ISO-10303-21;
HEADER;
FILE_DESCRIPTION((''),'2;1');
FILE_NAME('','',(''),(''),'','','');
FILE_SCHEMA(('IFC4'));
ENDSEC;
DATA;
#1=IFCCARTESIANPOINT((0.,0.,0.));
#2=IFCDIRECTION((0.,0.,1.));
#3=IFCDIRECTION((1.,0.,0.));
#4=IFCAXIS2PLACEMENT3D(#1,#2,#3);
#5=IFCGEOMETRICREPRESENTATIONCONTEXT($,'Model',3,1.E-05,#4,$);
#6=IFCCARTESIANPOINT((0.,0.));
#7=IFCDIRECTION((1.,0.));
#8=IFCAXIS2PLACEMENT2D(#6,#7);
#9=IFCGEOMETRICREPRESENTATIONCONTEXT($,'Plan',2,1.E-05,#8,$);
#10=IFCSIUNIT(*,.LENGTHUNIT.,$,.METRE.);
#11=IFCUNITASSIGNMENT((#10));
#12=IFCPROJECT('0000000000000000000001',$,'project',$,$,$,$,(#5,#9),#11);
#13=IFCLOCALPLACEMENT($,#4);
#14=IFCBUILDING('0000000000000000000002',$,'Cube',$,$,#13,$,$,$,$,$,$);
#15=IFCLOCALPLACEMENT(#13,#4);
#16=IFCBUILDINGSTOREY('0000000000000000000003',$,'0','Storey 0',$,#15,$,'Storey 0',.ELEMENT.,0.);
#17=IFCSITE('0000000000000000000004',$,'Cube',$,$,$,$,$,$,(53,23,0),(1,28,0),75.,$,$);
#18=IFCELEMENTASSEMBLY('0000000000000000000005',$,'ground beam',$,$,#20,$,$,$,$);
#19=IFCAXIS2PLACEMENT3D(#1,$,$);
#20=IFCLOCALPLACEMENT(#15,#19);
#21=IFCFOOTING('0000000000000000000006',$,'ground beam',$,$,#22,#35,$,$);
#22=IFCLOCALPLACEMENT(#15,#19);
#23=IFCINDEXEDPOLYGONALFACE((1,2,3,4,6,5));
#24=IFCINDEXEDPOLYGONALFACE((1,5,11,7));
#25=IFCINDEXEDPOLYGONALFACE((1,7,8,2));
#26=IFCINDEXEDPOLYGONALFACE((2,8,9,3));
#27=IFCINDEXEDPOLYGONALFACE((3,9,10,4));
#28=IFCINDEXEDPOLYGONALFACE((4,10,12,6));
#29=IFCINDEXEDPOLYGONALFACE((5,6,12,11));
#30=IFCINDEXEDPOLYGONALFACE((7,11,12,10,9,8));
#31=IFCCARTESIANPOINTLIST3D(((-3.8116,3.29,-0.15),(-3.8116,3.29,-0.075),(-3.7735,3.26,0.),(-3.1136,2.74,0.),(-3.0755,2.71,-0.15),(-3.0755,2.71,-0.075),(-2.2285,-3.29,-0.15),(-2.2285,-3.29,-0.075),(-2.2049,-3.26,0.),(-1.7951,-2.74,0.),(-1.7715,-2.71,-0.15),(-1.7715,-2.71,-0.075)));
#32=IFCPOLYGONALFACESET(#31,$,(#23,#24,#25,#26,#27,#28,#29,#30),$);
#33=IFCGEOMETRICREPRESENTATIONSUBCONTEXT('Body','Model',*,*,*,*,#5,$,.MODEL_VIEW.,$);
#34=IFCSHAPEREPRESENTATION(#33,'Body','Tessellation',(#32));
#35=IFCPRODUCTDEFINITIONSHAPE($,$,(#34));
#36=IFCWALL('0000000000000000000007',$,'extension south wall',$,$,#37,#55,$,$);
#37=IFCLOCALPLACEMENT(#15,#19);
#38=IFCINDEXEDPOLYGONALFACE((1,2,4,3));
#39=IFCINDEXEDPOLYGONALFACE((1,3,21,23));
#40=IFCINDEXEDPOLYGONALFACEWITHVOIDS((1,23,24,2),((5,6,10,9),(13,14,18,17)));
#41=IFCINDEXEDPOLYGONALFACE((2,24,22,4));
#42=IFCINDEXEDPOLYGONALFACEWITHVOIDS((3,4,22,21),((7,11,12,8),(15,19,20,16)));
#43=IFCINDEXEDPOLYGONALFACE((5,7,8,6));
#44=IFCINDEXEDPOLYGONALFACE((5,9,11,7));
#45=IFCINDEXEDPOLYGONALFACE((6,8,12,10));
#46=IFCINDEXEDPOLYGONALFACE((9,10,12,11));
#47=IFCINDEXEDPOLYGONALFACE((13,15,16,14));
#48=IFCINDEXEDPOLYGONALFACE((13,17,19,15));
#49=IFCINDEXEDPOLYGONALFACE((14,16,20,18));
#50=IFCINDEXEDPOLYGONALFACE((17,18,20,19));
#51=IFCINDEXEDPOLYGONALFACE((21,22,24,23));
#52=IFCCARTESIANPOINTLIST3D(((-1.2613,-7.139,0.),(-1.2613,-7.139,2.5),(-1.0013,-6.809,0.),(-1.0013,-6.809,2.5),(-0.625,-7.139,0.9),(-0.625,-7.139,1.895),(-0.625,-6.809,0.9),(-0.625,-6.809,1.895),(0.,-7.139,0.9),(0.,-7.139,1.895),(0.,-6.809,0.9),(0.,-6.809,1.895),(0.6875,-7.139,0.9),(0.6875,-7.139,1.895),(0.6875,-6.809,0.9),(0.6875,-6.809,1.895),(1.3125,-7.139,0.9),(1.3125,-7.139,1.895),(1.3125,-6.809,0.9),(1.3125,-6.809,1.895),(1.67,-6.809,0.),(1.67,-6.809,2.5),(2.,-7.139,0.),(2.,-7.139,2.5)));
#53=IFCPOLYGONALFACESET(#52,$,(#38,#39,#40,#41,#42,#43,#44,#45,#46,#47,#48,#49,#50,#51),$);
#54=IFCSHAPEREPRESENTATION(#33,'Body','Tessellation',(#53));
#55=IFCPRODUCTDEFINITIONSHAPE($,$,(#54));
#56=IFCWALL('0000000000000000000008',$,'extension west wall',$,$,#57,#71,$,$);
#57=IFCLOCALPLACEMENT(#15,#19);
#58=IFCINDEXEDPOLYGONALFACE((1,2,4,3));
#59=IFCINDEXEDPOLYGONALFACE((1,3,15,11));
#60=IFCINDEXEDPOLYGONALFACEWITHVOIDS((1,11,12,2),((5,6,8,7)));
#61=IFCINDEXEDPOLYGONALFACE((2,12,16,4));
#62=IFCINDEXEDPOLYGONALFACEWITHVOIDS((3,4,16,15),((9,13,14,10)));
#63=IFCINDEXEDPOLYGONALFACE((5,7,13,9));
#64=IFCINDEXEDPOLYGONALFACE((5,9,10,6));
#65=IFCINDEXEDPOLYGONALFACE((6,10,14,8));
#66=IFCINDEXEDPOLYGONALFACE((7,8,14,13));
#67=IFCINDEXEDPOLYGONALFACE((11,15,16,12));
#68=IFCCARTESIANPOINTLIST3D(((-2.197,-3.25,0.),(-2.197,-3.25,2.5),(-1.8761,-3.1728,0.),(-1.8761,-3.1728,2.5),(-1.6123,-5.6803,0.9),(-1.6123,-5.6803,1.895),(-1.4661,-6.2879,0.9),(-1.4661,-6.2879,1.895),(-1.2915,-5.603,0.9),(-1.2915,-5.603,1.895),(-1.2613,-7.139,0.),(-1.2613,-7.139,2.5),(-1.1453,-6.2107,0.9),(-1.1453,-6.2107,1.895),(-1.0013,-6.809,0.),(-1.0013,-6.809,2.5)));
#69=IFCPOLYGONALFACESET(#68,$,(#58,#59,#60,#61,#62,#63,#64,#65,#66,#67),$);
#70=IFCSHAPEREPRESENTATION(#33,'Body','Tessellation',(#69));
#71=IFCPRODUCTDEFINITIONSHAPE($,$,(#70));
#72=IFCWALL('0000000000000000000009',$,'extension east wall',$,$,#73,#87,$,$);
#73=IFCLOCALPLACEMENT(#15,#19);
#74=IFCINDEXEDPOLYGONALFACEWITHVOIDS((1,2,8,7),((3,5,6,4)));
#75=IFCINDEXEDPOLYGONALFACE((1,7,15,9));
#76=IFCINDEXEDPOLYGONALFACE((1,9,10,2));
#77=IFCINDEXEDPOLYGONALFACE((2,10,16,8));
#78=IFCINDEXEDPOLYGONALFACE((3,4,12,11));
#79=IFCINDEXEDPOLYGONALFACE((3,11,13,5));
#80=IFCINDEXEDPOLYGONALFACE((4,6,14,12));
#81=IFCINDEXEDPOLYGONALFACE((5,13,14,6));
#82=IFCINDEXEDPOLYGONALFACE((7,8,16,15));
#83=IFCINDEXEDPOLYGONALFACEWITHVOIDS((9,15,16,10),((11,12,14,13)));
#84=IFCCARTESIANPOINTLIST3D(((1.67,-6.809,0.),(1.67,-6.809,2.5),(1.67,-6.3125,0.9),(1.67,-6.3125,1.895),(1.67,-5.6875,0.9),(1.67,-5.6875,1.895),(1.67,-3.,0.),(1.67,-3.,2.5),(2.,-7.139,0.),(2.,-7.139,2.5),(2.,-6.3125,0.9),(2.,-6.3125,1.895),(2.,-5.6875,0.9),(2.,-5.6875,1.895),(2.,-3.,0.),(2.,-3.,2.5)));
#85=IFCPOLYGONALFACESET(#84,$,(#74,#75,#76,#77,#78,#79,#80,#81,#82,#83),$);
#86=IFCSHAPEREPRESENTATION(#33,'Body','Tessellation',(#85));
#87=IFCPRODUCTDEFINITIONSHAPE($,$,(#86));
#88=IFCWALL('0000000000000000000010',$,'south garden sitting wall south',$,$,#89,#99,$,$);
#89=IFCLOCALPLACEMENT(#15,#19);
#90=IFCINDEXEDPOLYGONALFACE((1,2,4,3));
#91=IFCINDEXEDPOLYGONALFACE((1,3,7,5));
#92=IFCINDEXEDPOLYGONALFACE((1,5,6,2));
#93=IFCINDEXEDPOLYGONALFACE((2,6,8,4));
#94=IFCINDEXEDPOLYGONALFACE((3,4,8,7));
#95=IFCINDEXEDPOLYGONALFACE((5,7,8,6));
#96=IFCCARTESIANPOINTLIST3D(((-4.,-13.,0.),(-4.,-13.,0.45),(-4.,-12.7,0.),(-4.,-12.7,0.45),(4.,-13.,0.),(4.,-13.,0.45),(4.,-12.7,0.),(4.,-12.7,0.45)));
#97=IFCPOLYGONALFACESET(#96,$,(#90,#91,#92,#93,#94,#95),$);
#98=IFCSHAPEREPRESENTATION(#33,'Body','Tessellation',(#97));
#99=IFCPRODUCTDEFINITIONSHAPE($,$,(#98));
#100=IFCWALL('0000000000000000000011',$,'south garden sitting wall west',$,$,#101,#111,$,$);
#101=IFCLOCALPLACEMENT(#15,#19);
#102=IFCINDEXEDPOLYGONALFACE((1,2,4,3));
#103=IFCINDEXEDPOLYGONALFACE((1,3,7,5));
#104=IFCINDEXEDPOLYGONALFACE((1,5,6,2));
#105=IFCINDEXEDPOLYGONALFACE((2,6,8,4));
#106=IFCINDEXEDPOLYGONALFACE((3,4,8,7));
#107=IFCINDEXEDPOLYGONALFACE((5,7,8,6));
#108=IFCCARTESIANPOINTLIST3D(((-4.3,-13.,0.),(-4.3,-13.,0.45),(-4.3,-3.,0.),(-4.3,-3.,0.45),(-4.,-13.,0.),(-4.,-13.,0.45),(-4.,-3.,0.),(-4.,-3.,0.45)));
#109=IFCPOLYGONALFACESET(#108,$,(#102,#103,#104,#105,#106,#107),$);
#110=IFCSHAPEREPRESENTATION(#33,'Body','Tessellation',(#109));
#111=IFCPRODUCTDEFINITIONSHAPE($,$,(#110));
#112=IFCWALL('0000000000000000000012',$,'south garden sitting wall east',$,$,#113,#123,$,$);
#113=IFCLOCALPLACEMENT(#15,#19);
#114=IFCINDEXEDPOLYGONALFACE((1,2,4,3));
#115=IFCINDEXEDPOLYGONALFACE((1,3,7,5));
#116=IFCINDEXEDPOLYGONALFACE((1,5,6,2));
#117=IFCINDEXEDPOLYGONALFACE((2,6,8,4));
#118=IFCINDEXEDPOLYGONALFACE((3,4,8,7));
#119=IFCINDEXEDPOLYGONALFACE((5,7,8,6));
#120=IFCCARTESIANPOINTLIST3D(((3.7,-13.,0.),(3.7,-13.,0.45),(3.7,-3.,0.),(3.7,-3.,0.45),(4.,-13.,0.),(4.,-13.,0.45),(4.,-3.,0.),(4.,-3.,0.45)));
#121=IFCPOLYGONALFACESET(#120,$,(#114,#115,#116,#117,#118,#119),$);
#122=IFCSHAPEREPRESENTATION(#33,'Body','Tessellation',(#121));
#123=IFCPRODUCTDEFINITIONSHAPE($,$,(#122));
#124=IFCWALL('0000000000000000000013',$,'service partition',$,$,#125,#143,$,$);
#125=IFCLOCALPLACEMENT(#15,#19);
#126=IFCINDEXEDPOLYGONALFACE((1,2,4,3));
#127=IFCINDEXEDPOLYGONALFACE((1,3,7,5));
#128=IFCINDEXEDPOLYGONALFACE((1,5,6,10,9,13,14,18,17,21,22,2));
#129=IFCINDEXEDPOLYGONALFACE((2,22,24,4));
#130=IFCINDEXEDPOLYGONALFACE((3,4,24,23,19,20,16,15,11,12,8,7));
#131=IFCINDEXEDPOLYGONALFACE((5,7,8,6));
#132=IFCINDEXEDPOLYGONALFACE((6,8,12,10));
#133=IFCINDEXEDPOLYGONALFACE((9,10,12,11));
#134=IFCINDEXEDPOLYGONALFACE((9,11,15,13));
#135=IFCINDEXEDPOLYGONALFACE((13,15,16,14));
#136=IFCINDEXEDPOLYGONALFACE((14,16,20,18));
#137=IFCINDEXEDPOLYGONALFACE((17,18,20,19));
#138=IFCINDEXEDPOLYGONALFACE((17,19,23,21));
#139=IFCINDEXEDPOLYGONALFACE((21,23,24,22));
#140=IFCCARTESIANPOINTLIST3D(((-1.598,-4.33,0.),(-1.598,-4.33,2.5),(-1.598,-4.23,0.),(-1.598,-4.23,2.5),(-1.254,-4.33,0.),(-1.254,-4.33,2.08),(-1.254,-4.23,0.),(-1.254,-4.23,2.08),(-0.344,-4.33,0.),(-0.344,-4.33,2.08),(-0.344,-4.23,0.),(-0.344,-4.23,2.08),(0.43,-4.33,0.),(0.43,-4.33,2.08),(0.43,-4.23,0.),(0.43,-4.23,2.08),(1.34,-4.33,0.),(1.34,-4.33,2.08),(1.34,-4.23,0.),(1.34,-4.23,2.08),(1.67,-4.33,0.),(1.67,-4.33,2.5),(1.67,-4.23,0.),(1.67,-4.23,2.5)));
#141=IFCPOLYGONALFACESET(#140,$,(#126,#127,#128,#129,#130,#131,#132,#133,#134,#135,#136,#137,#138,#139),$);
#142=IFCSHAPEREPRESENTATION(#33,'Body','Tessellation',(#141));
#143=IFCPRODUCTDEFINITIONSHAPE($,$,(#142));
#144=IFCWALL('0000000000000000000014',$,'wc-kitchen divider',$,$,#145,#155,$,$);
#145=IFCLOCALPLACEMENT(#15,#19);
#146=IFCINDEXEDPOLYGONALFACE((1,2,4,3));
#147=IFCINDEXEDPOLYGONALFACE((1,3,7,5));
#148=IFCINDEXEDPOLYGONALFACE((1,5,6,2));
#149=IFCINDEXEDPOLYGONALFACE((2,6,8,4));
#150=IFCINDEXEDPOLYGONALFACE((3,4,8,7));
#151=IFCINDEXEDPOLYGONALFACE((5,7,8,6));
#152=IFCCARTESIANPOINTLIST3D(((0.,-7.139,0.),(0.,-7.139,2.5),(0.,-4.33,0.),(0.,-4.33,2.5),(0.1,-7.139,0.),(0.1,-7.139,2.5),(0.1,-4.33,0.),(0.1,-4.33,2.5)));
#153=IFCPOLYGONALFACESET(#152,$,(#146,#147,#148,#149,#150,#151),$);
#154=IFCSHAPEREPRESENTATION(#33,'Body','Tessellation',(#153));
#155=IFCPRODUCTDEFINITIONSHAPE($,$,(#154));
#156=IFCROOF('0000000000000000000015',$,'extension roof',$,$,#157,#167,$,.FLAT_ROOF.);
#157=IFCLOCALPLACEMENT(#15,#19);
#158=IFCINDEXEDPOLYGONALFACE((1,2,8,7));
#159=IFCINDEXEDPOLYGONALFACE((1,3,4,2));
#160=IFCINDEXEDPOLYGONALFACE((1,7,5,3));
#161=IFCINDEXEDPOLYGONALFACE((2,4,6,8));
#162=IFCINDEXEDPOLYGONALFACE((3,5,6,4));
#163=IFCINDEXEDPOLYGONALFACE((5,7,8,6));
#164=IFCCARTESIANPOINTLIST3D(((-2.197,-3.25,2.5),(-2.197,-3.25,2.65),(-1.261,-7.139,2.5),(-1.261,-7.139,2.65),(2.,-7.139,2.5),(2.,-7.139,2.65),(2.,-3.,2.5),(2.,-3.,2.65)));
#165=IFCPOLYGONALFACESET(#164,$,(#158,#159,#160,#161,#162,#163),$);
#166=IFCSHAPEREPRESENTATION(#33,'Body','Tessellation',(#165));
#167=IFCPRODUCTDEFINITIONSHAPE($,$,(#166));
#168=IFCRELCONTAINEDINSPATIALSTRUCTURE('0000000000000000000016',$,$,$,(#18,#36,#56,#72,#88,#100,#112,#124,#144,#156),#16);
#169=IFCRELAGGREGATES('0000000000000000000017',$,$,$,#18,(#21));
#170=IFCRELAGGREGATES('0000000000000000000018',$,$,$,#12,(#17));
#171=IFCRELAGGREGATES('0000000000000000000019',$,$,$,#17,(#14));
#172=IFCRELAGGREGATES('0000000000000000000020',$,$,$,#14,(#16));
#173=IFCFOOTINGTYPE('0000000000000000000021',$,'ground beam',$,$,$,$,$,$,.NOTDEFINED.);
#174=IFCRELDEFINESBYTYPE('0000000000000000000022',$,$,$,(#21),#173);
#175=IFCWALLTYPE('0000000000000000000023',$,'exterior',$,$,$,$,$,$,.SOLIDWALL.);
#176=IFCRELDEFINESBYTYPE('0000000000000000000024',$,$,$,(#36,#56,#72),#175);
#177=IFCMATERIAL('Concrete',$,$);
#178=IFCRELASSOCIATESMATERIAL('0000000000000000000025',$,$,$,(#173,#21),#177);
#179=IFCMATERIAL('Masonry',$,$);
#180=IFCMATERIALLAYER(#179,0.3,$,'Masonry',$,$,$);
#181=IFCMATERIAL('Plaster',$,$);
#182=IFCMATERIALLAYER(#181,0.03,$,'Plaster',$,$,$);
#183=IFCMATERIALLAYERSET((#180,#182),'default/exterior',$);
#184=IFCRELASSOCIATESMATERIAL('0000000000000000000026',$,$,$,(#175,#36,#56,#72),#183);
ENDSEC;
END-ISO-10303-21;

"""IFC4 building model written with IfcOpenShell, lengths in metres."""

from ifc_helpers import new_model, si_unit, frame, origin_with_axes, origin_2d_with_axis, place, context, subcontext, project, spatial, polyline, line, indexed_curve, outline, extrude, clip, halfspace, material, layer, layer_set, layer_usage, material_profile, profile_set, profile_usage, type_object, element, aggregate, save


model = new_model("IFC4")

# Units and contexts
model_context = context("Model", 3, precision=1e-05, world=origin_with_axes())
plan_context = context("Plan", 2, precision=1e-05, world=origin_2d_with_axis())
body_context_1 = subcontext(model_context, "Body", "Model", "MODEL_VIEW")
ifc_project = project(units=[si_unit("LENGTHUNIT", "METRE")], contexts=[model_context, plan_context])

# Site, building, storey
site = spatial("IfcSite", under=ifc_project, Name="Cube", RefLatitude=(53, 23, 0), RefLongitude=(1, 28, 0), RefElevation=75.0)
building_placement = place(None, origin_with_axes())
building = spatial("IfcBuilding", under=site, at=building_placement, Name="Cube")
storey_placement = place(building_placement, origin_with_axes())
storey = spatial("IfcBuildingStorey", under=building, at=storey_placement, Name="0", Description="Storey 0", LongName="Storey 0", CompositionType="ELEMENT", Elevation=0.0)

# Element assembly, footing
assembly_placement = place(storey_placement, origin_with_axes())
assembly = element("IfcElementAssembly", 1, at=assembly_placement, inside=storey, Name="ground beam")
ifc_material_1 = material(Name="Concrete")
ifc_material_profile = material_profile(ifc_material_1, outline(polyline([(-0.26, 0.0), (-0.29, -0.075), (-0.29, -0.15), (0.29, -0.15), (0.29, -0.075), (0.26, 0.0), (-0.26, 0.0)])))
ifc_profile_set = profile_set([ifc_material_profile])
ifc_profile_usage = profile_usage(ifc_profile_set)
footing_type = type_object("IfcFootingType", Name="ground beam", PredefinedType="NOTDEFINED", material=ifc_profile_set)
footing_placement = place(assembly_placement, frame((-1.7661, -3.9723, 0.0), z_axis=(-0.233915, 0.972257, 0.0), x_axis=(-0.972257, -0.233915, 0.0)))
footing = element("IfcFooting", 2, at=footing_placement, type_object=footing_type, material=ifc_profile_usage, Name="ground beam", context=body_context_1, shape_type="Clipping", body=[
    clip(clip(extrude(outline(polyline([(-0.26, 0.0), (-0.29, -0.075), (-0.29, -0.15), (0.29, -0.15), (0.29, -0.075), (0.26, 0.0), (-0.26, 0.0)])), origin_with_axes(), (0.0, 0.0, 1.0), 8.1712), halfspace(frame((0.0, 0.0, 1.0), z_axis=(-0.618904, 0.0, -0.785467), x_axis=(0.0, 1.0, 0.0)), False)), halfspace(frame((0.0, 0.0, 7.1712), z_axis=(-0.785467, 0.0, 0.618904), x_axis=(0.0, 1.0, 0.0)), False)),
])
aggregate(assembly, [footing])

# Wall, openings
ifc_material_2 = material(Name="Masonry")
ifc_layer_1 = layer(ifc_material_2, 0.3, Name="Masonry")
ifc_material_3 = material(Name="Plaster")
ifc_layer_2 = layer(ifc_material_3, 0.03, Name="Plaster")
ifc_layer_set = layer_set([ifc_layer_1, ifc_layer_2], Name="default/exterior")
ifc_layer_usage = layer_usage(ifc_layer_set, "AXIS2", "POSITIVE", 0.0)
wall_type = type_object("IfcWallType", Name="exterior", PredefinedType="SOLIDWALL", material=ifc_layer_set)
wall_1_placement = place(storey_placement, frame((-1.2613, -7.139, 0.0), z_axis=(0.0, 0.0, 1.0), x_axis=(1.0, 0.0, 0.0)))
wall_1 = element("IfcWall", 3, at=wall_1_placement, inside=storey, type_object=wall_type, material=ifc_layer_usage, Name="extension south wall", context=body_context_1, shape_type="SweptSolid", body=[
    extrude(outline(indexed_curve([(0.0, 0.0), (0.26, 0.33), (2.9313, 0.33), (3.2613, 0.0)], segments=[line(1, 2, 3, 4, 1)])), origin_with_axes(), (0.0, 0.0, 1.0), 2.5),
])
opening_1_placement = place(wall_1_placement, frame((0.6363, 0.0, 0.9), z_axis=(0.0, 0.0, 1.0), x_axis=(1.0, 0.0, 0.0)))
element("IfcOpeningElement", 4, at=opening_1_placement, cuts=wall_1, PredefinedType="OPENING", context=body_context_1, shape_type="SweptSolid", body=[
    extrude(outline(indexed_curve([(0.0, 0.0), (0.0, 0.5), (0.625, 0.5), (0.625, 0.0), (0.0, 0.0)], self_intersect=False)), origin_with_axes(), (0.0, 0.0, 1.0), 0.995),
])
opening_2_placement = place(wall_1_placement, frame((1.9488, 0.0, 0.9), z_axis=(0.0, 0.0, 1.0), x_axis=(1.0, 0.0, 0.0)))
element("IfcOpeningElement", 5, at=opening_2_placement, cuts=wall_1, PredefinedType="OPENING", context=body_context_1, shape_type="SweptSolid", body=[
    extrude(outline(indexed_curve([(0.0, 0.0), (0.0, 0.5), (0.625, 0.5), (0.625, 0.0), (0.0, 0.0)], self_intersect=False)), origin_with_axes(), (0.0, 0.0, 1.0), 0.995),
])

# Walls, openings
wall_2_placement = place(storey_placement, frame((-2.197, -3.25, 0.0), z_axis=(0.0, 0.0, 1.0), x_axis=(0.233916, -0.972257, 0.0)))
wall_2 = element("IfcWall", 6, at=wall_2_placement, inside=storey, type_object=wall_type, material=ifc_layer_usage, Name="extension west wall", context=body_context_1, shape_type="SweptSolid", body=[
    extrude(outline(indexed_curve([(0.0, 0.0), (0.0, 0.33), (3.7399, 0.33), (4.0, 0.0)], segments=[line(1, 2, 3, 4, 1)])), origin_with_axes(), (0.0, 0.0, 1.0), 2.5),
])
opening_3_placement = place(wall_2_placement, frame((2.4996, -0.0501, 0.9), z_axis=(0.0, 0.0, 1.0), x_axis=(1.0, 0.000142, 0.0)))
element("IfcOpeningElement", 7, at=opening_3_placement, cuts=wall_2, PredefinedType="OPENING", context=body_context_1, shape_type="SweptSolid", body=[
    extrude(outline(indexed_curve([(0.0, 0.0), (0.0, 0.43), (0.625, 0.43), (0.625, 0.0), (0.0, 0.0)], self_intersect=False)), origin_with_axes(), (0.0, 0.0, 1.0), 0.995),
])
wall_3_placement = place(storey_placement, frame((2.0, -7.139, 0.0), z_axis=(0.0, 0.0, 1.0), x_axis=(0.0, 1.0, 0.0)))
wall_3 = element("IfcWall", 8, at=wall_3_placement, inside=storey, type_object=wall_type, material=ifc_layer_usage, Name="extension east wall", context=body_context_1, shape_type="SweptSolid", body=[
    extrude(outline(indexed_curve([(0.0, 0.0), (0.33, 0.33), (4.139, 0.33), (4.139, 0.0)], segments=[line(1, 2, 3, 4, 1)])), origin_with_axes(), (0.0, 0.0, 1.0), 2.5),
])
opening_4_placement = place(wall_3_placement, frame((0.8265, 0.0, 0.9), z_axis=(0.0, 0.0, 1.0), x_axis=(1.0, 0.0, 0.0)))
element("IfcOpeningElement", 9, at=opening_4_placement, cuts=wall_3, PredefinedType="OPENING", context=body_context_1, shape_type="SweptSolid", body=[
    extrude(outline(indexed_curve([(0.0, 0.0), (0.0, 0.5), (0.625, 0.5), (0.625, 0.0), (0.0, 0.0)], self_intersect=False)), origin_with_axes(), (0.0, 0.0, 1.0), 0.995),
])

# Walls
wall_4_placement = place(storey_placement, frame((-4.0, -13.0, 0.0), z_axis=(0.0, 0.0, 1.0), x_axis=(1.0, 0.0, 0.0)))
element("IfcWall", 10, at=wall_4_placement, inside=storey, Name="south garden sitting wall south", context=body_context_1, shape_type="SweptSolid", body=[
    extrude(outline(indexed_curve([(0.0, 0.0), (0.0, 0.3), (8.0, 0.3), (8.0, 0.0), (0.0, 0.0)], self_intersect=False)), origin_with_axes(), (0.0, 0.0, 1.0), 0.45),
])
for number, where, z_axis, x_axis, name in (
    (11, (-4.0, -13.0, 0.0), (0.0, 0.0, 1.0), (0.0, 1.0, 0.0), "south garden sitting wall west"),
    (12, (4.0, -13.0, 0.0), (0.0, 0.0, 1.0), (0.0, 1.0, 0.0), "south garden sitting wall east"),
):
    element("IfcWall", number, at=place(storey_placement, frame(where, z_axis=z_axis, x_axis=x_axis)), inside=storey, Name=name, context=body_context_1, shape_type="SweptSolid", body=[
        extrude(outline(indexed_curve([(0.0, 0.0), (0.0, 0.3), (10.0, 0.3), (10.0, 0.0), (0.0, 0.0)], self_intersect=False)), origin_with_axes(), (0.0, 0.0, 1.0), 0.45),
    ])

# Wall, openings
wall_5_placement = place(storey_placement, frame((-1.598, -4.33, 0.0), z_axis=(0.0, 0.0, 1.0), x_axis=(1.0, 0.0, 0.0)))
wall_5 = element("IfcWall", 13, at=wall_5_placement, inside=storey, Name="service partition", context=body_context_1, shape_type="SweptSolid", body=[
    extrude(outline(indexed_curve([(0.0, 0.0), (0.0, 0.1), (3.268, 0.1), (3.268, 0.0), (0.0, 0.0)], self_intersect=False)), origin_with_axes(), (0.0, 0.0, 1.0), 2.5),
])
opening_5_placement = place(wall_5_placement, frame((0.344, -0.05, 0.0), z_axis=(0.0, 0.0, 1.0), x_axis=(1.0, 0.0, 0.0)))
element("IfcOpeningElement", 14, at=opening_5_placement, cuts=wall_5, context=body_context_1, shape_type="SweptSolid", body=[
    extrude(outline(indexed_curve([(0.0, 0.0), (0.0, 0.3), (0.91, 0.3), (0.91, 0.0), (0.0, 0.0)], self_intersect=False)), origin_with_axes(), (0.0, 0.0, 1.0), 2.08),
])
opening_6_placement = place(wall_5_placement, frame((2.028, -0.05, 0.0), z_axis=(0.0, 0.0, 1.0), x_axis=(1.0, 0.0, 0.0)))
element("IfcOpeningElement", 15, at=opening_6_placement, cuts=wall_5, context=body_context_1, shape_type="SweptSolid", body=[
    extrude(outline(indexed_curve([(0.0, 0.0), (0.0, 0.3), (0.91, 0.3), (0.91, 0.0), (0.0, 0.0)], self_intersect=False)), origin_with_axes(), (0.0, 0.0, 1.0), 2.08),
])

# Wall
wall_6_placement = place(storey_placement, frame((0.0, -4.33, 0.0), z_axis=(0.0, 0.0, 1.0), x_axis=(0.0, -1.0, 0.0)))
element("IfcWall", 16, at=wall_6_placement, inside=storey, Name="wc-kitchen divider", context=body_context_1, shape_type="SweptSolid", body=[
    extrude(outline(indexed_curve([(0.0, 0.0), (0.0, 0.1), (2.809, 0.1), (2.809, 0.0), (0.0, 0.0)], self_intersect=False)), origin_with_axes(), (0.0, 0.0, 1.0), 2.5),
])

# Roof
roof_placement = place(storey_placement, frame((-1.261, -7.139, 2.5), z_axis=(0.0, 0.0, 1.0), x_axis=(1.0, 0.0, 0.0)))
element("IfcRoof", 17, at=roof_placement, inside=storey, Name="extension roof", PredefinedType="FLAT_ROOF", context=body_context_1, shape_type="SweptSolid", body=[
    extrude(outline(indexed_curve([(0.0, 0.0), (3.261, 0.0), (3.261, 4.139), (-0.936, 3.889)])), None, (0.0, 0.0, 1.0), 0.15),
])

save(model, "model.ifc")
